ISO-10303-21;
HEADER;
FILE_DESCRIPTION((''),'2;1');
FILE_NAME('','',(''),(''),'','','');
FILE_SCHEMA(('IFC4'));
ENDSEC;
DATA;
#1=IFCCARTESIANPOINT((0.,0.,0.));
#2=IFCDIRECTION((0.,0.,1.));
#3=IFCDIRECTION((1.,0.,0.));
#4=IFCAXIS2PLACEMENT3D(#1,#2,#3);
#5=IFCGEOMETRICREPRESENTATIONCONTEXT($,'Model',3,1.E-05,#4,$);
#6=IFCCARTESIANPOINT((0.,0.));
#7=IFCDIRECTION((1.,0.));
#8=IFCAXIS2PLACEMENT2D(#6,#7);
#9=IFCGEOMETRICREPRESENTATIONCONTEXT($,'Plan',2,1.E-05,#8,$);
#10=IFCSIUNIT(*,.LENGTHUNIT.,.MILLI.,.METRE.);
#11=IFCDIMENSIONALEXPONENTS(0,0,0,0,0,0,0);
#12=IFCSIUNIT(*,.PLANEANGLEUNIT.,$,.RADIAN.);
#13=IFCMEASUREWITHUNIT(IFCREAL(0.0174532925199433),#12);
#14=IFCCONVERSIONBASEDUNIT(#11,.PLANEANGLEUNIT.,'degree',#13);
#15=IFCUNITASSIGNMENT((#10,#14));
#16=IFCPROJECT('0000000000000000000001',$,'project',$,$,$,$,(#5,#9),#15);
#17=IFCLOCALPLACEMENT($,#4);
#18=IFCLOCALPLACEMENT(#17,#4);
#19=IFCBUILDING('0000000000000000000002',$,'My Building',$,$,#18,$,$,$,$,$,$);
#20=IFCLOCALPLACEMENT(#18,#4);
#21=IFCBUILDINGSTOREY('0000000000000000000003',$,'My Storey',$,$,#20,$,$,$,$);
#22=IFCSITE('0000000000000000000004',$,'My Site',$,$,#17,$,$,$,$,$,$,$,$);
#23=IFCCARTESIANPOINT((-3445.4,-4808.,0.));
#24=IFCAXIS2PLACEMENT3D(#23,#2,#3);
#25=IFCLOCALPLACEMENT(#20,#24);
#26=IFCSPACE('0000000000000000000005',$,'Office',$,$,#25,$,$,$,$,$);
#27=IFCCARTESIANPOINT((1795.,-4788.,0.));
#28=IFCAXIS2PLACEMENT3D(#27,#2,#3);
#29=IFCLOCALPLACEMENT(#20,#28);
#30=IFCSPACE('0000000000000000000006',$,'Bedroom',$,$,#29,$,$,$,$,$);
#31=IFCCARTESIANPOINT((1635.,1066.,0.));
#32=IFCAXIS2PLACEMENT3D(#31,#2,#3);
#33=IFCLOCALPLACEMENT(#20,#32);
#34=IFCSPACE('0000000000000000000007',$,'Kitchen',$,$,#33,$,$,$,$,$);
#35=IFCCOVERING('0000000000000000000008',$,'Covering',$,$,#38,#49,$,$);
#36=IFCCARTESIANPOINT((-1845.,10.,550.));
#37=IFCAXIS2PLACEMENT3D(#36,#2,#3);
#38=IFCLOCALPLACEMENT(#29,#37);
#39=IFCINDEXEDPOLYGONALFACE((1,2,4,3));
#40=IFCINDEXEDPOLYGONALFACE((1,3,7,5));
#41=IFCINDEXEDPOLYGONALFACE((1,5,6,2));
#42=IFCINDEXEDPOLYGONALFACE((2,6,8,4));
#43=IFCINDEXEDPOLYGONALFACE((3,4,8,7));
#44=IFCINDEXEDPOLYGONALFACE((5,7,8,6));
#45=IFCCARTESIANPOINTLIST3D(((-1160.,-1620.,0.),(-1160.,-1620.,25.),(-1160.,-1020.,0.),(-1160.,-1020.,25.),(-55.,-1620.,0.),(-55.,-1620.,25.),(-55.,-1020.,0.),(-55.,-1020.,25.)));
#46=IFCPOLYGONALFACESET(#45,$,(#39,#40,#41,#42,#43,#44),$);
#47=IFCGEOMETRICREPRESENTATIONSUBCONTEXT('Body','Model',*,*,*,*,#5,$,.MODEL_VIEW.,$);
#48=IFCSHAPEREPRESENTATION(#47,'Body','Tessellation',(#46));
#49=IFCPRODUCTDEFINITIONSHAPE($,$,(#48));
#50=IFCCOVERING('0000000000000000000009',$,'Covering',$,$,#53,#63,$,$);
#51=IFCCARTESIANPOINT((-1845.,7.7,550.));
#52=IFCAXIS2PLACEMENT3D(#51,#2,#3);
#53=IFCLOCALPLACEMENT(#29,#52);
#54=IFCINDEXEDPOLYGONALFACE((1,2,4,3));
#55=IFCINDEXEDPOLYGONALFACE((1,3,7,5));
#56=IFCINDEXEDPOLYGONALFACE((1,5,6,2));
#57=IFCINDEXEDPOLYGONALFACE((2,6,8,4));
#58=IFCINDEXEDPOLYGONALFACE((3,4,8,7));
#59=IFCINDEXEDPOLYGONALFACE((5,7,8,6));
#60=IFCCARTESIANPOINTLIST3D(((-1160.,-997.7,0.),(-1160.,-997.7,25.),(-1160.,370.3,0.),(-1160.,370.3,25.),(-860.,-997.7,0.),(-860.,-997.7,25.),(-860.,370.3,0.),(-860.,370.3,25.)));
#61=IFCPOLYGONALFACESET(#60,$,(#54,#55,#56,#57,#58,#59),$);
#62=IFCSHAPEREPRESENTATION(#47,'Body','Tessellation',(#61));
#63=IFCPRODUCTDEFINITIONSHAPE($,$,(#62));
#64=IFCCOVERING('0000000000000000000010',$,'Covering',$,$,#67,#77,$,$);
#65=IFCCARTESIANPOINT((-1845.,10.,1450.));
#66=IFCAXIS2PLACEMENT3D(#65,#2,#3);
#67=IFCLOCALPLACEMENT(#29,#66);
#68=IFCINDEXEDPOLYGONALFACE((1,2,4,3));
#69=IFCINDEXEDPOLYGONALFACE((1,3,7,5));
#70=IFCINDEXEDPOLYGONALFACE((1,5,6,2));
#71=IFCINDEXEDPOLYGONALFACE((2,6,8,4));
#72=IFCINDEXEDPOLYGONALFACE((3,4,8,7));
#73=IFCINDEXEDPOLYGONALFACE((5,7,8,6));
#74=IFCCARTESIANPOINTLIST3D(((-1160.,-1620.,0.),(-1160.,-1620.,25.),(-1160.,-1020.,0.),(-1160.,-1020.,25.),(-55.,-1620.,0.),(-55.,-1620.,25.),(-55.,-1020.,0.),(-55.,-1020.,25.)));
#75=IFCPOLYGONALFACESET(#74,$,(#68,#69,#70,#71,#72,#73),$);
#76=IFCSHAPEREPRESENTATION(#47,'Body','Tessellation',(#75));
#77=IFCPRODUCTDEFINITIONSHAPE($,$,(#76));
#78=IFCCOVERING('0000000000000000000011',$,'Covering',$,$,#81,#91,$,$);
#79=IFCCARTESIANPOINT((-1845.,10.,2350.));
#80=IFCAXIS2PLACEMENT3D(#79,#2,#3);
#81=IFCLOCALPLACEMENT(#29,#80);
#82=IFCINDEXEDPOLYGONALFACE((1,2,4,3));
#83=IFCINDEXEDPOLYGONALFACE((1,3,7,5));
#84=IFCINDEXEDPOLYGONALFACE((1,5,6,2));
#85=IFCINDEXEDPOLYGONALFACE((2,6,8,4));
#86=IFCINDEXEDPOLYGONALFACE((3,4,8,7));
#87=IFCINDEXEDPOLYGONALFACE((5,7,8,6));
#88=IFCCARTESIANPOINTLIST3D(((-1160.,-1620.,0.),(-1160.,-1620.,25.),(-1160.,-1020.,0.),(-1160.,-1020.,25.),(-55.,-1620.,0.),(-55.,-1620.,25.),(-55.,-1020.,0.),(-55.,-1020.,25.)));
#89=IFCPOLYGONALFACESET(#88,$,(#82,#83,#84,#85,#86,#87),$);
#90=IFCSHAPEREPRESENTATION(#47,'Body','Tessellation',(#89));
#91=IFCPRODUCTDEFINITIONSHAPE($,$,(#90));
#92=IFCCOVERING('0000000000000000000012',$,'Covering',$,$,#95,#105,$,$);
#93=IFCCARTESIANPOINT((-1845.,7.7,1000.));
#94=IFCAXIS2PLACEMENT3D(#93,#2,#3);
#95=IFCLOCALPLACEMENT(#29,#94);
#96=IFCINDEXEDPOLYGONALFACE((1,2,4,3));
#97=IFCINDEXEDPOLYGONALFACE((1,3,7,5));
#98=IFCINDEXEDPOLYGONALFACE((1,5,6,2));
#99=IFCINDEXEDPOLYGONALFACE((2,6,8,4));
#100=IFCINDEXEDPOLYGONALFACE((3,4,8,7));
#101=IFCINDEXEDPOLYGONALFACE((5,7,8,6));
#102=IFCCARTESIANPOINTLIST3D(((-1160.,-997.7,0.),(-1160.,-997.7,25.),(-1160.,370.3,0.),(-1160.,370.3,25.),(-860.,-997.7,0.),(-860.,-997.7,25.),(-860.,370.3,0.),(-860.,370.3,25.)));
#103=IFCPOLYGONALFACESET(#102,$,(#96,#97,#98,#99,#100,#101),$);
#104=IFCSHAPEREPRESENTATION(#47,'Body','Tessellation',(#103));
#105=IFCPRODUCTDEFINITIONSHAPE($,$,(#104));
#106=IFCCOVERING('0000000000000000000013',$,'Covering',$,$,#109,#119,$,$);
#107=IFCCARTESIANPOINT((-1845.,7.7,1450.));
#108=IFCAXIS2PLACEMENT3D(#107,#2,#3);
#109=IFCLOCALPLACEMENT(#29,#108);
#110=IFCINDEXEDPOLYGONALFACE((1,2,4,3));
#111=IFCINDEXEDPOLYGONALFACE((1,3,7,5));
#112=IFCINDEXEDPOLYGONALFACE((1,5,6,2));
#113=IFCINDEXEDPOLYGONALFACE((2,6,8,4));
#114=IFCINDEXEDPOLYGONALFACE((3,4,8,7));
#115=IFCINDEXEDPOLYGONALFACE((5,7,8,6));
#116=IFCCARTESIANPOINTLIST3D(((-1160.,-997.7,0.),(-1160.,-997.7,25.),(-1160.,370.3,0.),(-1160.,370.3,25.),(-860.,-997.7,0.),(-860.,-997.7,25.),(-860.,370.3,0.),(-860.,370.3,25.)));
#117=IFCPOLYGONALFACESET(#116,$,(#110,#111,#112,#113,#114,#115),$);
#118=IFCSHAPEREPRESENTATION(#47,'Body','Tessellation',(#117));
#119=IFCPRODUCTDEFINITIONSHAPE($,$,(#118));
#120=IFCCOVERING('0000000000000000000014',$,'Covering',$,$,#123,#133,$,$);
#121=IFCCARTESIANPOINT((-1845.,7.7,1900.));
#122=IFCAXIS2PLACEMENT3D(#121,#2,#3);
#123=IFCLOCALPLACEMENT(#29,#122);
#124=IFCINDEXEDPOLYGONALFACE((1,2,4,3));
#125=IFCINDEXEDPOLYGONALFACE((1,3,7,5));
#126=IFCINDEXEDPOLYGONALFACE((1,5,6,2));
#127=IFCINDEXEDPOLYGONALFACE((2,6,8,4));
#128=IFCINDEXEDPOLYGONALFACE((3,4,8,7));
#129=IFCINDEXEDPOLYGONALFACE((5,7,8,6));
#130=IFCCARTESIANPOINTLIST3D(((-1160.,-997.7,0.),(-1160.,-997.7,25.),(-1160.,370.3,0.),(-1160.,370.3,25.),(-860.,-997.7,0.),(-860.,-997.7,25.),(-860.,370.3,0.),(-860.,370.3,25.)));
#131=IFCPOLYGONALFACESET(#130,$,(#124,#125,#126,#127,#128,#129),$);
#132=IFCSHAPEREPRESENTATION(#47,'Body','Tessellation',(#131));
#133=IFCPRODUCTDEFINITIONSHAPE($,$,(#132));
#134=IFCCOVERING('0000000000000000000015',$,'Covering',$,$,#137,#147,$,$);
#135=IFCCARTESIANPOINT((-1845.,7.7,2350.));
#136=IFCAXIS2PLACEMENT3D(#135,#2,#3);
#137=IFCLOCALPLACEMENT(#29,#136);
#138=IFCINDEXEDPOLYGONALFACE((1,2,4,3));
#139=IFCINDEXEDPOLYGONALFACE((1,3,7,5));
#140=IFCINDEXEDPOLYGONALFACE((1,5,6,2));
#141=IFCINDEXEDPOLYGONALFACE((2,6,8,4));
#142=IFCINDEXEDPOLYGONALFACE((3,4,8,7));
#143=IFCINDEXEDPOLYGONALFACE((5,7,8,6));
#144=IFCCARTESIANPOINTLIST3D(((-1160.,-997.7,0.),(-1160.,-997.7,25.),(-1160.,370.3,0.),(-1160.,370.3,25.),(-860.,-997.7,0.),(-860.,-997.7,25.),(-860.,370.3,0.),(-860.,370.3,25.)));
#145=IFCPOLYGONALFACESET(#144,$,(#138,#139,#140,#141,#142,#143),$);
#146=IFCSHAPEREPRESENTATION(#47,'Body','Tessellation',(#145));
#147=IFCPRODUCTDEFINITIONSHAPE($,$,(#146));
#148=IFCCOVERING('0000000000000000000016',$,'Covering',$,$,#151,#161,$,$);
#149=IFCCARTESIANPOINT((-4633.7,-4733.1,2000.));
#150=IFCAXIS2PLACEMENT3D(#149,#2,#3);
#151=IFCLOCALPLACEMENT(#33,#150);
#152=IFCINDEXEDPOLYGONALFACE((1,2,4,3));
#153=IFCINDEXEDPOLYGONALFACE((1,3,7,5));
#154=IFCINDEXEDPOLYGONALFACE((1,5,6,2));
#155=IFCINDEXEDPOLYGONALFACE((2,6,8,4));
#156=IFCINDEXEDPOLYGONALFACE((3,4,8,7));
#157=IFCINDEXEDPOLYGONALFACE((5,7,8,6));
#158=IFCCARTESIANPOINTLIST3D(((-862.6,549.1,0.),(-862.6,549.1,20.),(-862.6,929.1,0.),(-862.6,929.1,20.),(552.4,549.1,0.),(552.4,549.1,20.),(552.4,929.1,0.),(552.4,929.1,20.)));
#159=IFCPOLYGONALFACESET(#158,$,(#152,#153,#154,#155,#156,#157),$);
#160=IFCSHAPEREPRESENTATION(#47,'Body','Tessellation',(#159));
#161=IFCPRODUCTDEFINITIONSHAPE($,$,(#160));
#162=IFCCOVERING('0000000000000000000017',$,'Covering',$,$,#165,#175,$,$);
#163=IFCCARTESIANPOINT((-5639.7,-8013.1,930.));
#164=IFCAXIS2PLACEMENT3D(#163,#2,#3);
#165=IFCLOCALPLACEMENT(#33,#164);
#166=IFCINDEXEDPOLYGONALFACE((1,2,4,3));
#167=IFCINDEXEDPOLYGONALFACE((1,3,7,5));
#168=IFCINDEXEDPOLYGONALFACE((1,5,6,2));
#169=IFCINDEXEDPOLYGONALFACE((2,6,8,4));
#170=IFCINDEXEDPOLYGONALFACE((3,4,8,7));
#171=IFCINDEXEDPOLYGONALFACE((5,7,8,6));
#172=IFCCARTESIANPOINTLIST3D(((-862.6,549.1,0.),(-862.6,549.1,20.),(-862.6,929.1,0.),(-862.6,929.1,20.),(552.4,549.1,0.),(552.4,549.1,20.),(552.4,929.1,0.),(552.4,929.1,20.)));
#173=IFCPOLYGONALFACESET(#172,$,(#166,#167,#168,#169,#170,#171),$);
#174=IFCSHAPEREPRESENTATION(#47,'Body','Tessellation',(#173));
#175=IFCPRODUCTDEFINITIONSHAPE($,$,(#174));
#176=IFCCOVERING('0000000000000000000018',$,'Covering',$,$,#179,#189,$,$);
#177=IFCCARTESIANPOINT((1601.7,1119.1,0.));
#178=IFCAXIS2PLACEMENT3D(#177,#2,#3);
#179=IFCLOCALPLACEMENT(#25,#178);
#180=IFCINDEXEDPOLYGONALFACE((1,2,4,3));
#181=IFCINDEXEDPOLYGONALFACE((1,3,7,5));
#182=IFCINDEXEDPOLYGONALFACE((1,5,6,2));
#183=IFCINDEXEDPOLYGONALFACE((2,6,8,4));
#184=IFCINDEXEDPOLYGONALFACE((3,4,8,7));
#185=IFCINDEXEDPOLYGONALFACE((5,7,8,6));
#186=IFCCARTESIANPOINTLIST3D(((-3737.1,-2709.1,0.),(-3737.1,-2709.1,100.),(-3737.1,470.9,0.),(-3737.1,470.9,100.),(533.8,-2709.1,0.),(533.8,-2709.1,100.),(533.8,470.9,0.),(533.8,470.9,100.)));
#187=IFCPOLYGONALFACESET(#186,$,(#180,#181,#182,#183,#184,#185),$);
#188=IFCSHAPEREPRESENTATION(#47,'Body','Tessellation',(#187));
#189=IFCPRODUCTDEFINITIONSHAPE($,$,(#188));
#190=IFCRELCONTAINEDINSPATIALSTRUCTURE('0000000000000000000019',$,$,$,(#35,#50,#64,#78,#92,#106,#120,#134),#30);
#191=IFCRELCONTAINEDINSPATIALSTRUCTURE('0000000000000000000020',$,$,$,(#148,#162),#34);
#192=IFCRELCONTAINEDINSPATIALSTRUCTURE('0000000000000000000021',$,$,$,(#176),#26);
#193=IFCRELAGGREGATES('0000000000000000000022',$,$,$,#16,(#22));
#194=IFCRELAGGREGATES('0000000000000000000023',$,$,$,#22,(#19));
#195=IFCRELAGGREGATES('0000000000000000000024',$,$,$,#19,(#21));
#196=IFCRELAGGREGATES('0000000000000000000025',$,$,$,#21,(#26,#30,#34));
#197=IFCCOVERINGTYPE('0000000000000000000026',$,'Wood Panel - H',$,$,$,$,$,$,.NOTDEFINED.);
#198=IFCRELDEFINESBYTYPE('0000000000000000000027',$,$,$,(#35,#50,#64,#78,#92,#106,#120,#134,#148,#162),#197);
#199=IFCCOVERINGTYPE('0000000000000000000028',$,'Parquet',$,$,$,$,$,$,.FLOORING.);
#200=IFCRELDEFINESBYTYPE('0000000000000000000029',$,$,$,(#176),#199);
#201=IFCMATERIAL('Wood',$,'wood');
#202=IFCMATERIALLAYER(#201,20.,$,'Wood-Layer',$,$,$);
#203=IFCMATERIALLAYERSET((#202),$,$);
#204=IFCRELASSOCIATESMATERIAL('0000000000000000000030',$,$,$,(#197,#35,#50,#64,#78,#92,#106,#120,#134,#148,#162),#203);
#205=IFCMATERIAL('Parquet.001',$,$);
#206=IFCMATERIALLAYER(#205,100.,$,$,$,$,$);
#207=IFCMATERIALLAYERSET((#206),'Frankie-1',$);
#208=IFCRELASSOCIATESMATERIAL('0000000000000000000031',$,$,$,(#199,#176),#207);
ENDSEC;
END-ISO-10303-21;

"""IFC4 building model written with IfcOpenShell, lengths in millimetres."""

from ifc_helpers import new_model, entity, si_unit, converted_unit, frame, origin_with_axes, origin_2d_with_axis, place, context, subcontext, project, spatial, line, indexed_curve, outline, extrude, material, layer, layer_set, layer_usage, type_object, element, save


model = new_model("IFC4")

# Units and contexts
model_context = context("Model", 3, precision=1e-05, world=origin_with_axes())
plan_context = context("Plan", 2, precision=1e-05, world=origin_2d_with_axis())
body_context_1 = subcontext(model_context, "Body", "Model", "MODEL_VIEW")
ifc_project = project(units=[si_unit("LENGTHUNIT", "METRE", prefix="MILLI"), converted_unit("PLANEANGLEUNIT", "degree", entity("IfcReal", 0.0174532925199433), si_unit("PLANEANGLEUNIT", "RADIAN"), dimensions=[0, 0, 0, 0, 0, 0, 0])], contexts=[model_context, plan_context])

# Site, building, storey
site_placement = place(None, origin_with_axes())
site = spatial("IfcSite", under=ifc_project, at=site_placement, Name="My Site")
building_placement = place(site_placement, origin_with_axes())
building = spatial("IfcBuilding", under=site, at=building_placement, Name="My Building")
storey_placement = place(building_placement, origin_with_axes())
storey = spatial("IfcBuildingStorey", under=building, at=storey_placement, Name="My Storey")

# Shared definitions
space_1_placement = place(storey_placement, frame((-3445.4, -4808.0, 0.0), z_axis=(0.0, 0.0, 1.0), x_axis=(1.0, 0.0, 0.0)))
space_1 = spatial("IfcSpace", under=storey, at=space_1_placement, Name="Office")

# Shared definitions
space_2_placement = place(storey_placement, frame((1795.0, -4788.0, 0.0), z_axis=(0.0, 0.0, 1.0), x_axis=(1.0, 0.0, 0.0)))
space_2 = spatial("IfcSpace", under=storey, at=space_2_placement, Name="Bedroom")

# Coverings
ifc_material_1 = material(Name="Wood", Category="wood")
ifc_layer_1 = layer(ifc_material_1, 20.0, Name="Wood-Layer")
ifc_layer_set_1 = layer_set([ifc_layer_1])
covering_type_1 = type_object("IfcCoveringType", Name="Wood Panel - H", PredefinedType="NOTDEFINED", material=ifc_layer_set_1)
ifc_layer_usage_1 = layer_usage(ifc_layer_set_1, "AXIS3", "POSITIVE", 0.0)
covering_1_placement = place(space_2_placement, frame((-1845.0, 10.0, 550.0), z_axis=(0.0, 0.0, 1.0), x_axis=(1.0, 0.0, 0.0)))
element("IfcCovering", 1, at=covering_1_placement, inside=space_2, type_object=covering_type_1, material=ifc_layer_usage_1, Name="Covering", context=body_context_1, shape_type="SweptSolid", body=[
    extrude(outline(indexed_curve([(-55.0, -1020.0), (-1160.0, -1020.0), (-1160.0, -1620.0), (-55.0, -1620.0)], segments=[line(3, 2), line(2, 1), line(1, 4), line(4, 3)], self_intersect=False)), None, (0.0, 0.0, 1.0), 25.0),
])
ifc_layer_usage_2 = layer_usage(ifc_layer_set_1, "AXIS3", "POSITIVE", 0.0)
covering_2_placement = place(space_2_placement, frame((-1845.0, 7.7, 550.0), z_axis=(0.0, 0.0, 1.0), x_axis=(1.0, 0.0, 0.0)))
element("IfcCovering", 2, at=covering_2_placement, inside=space_2, type_object=covering_type_1, material=ifc_layer_usage_2, Name="Covering", context=body_context_1, shape_type="SweptSolid", body=[
    extrude(outline(indexed_curve([(-860.0, 370.3), (-860.0, -997.7), (-1160.0, -997.7), (-1160.0, 370.3)], segments=[line(3, 2), line(2, 1), line(1, 4), line(4, 3)], self_intersect=False)), None, (0.0, 0.0, 1.0), 25.0),
])
ifc_layer_usage_3 = layer_usage(ifc_layer_set_1, "AXIS3", "POSITIVE", 0.0)
covering_3_placement = place(space_2_placement, frame((-1845.0, 10.0, 1450.0), z_axis=(0.0, 0.0, 1.0), x_axis=(1.0, 0.0, 0.0)))
element("IfcCovering", 3, at=covering_3_placement, inside=space_2, type_object=covering_type_1, material=ifc_layer_usage_3, Name="Covering", context=body_context_1, shape_type="SweptSolid", body=[
    extrude(outline(indexed_curve([(-55.0, -1020.0), (-1160.0, -1020.0), (-1160.0, -1620.0), (-55.0, -1620.0)], segments=[line(3, 2), line(2, 1), line(1, 4), line(4, 3)], self_intersect=False)), None, (0.0, 0.0, 1.0), 25.0),
])
ifc_layer_usage_4 = layer_usage(ifc_layer_set_1, "AXIS3", "POSITIVE", 0.0)
covering_4_placement = place(space_2_placement, frame((-1845.0, 10.0, 2350.0), z_axis=(0.0, 0.0, 1.0), x_axis=(1.0, 0.0, 0.0)))
element("IfcCovering", 4, at=covering_4_placement, inside=space_2, type_object=covering_type_1, material=ifc_layer_usage_4, Name="Covering", context=body_context_1, shape_type="SweptSolid", body=[
    extrude(outline(indexed_curve([(-55.0, -1020.0), (-1160.0, -1020.0), (-1160.0, -1620.0), (-55.0, -1620.0)], segments=[line(3, 2), line(2, 1), line(1, 4), line(4, 3)], self_intersect=False)), None, (0.0, 0.0, 1.0), 25.0),
])
ifc_layer_usage_5 = layer_usage(ifc_layer_set_1, "AXIS3", "POSITIVE", 0.0)
covering_5_placement = place(space_2_placement, frame((-1845.0, 7.7, 1000.0), z_axis=(0.0, 0.0, 1.0), x_axis=(1.0, 0.0, 0.0)))
element("IfcCovering", 5, at=covering_5_placement, inside=space_2, type_object=covering_type_1, material=ifc_layer_usage_5, Name="Covering", context=body_context_1, shape_type="SweptSolid", body=[
    extrude(outline(indexed_curve([(-860.0, 370.3), (-860.0, -997.7), (-1160.0, -997.7), (-1160.0, 370.3)], segments=[line(3, 2), line(2, 1), line(1, 4), line(4, 3)], self_intersect=False)), None, (0.0, 0.0, 1.0), 25.0),
])
ifc_layer_usage_6 = layer_usage(ifc_layer_set_1, "AXIS3", "POSITIVE", 0.0)
covering_6_placement = place(space_2_placement, frame((-1845.0, 7.7, 1450.0), z_axis=(0.0, 0.0, 1.0), x_axis=(1.0, 0.0, 0.0)))
element("IfcCovering", 6, at=covering_6_placement, inside=space_2, type_object=covering_type_1, material=ifc_layer_usage_6, Name="Covering", context=body_context_1, shape_type="SweptSolid", body=[
    extrude(outline(indexed_curve([(-860.0, 370.3), (-860.0, -997.7), (-1160.0, -997.7), (-1160.0, 370.3)], segments=[line(3, 2), line(2, 1), line(1, 4), line(4, 3)], self_intersect=False)), None, (0.0, 0.0, 1.0), 25.0),
])
ifc_layer_usage_7 = layer_usage(ifc_layer_set_1, "AXIS3", "POSITIVE", 0.0)
covering_7_placement = place(space_2_placement, frame((-1845.0, 7.7, 1900.0), z_axis=(0.0, 0.0, 1.0), x_axis=(1.0, 0.0, 0.0)))
element("IfcCovering", 7, at=covering_7_placement, inside=space_2, type_object=covering_type_1, material=ifc_layer_usage_7, Name="Covering", context=body_context_1, shape_type="SweptSolid", body=[
    extrude(outline(indexed_curve([(-860.0, 370.3), (-860.0, -997.7), (-1160.0, -997.7), (-1160.0, 370.3)], segments=[line(3, 2), line(2, 1), line(1, 4), line(4, 3)], self_intersect=False)), None, (0.0, 0.0, 1.0), 25.0),
])
ifc_layer_usage_8 = layer_usage(ifc_layer_set_1, "AXIS3", "POSITIVE", 0.0)
covering_8_placement = place(space_2_placement, frame((-1845.0, 7.7, 2350.0), z_axis=(0.0, 0.0, 1.0), x_axis=(1.0, 0.0, 0.0)))
element("IfcCovering", 8, at=covering_8_placement, inside=space_2, type_object=covering_type_1, material=ifc_layer_usage_8, Name="Covering", context=body_context_1, shape_type="SweptSolid", body=[
    extrude(outline(indexed_curve([(-860.0, 370.3), (-860.0, -997.7), (-1160.0, -997.7), (-1160.0, 370.3)], segments=[line(3, 2), line(2, 1), line(1, 4), line(4, 3)], self_intersect=False)), None, (0.0, 0.0, 1.0), 25.0),
])

# Shared definitions
space_3_placement = place(storey_placement, frame((1635.0, 1066.0, 0.0), z_axis=(0.0, 0.0, 1.0), x_axis=(1.0, 0.0, 0.0)))
space_3 = spatial("IfcSpace", under=storey, at=space_3_placement, Name="Kitchen")

# Coverings
ifc_layer_usage_9 = layer_usage(ifc_layer_set_1, "AXIS3", "POSITIVE", 0.0)
covering_9_placement = place(space_3_placement, frame((-4633.7, -4733.1, 2000.0), z_axis=(0.0, 0.0, 1.0), x_axis=(1.0, 0.0, 0.0)))
element("IfcCovering", 9, at=covering_9_placement, inside=space_3, type_object=covering_type_1, material=ifc_layer_usage_9, Name="Covering", context=body_context_1, shape_type="SweptSolid", body=[
    extrude(outline(indexed_curve([(552.4, 549.1), (552.4, 929.1), (-862.6, 929.1), (-862.6, 549.1), (552.4, 549.1)])), None, (0.0, 0.0, 1.0), 20.0),
])
ifc_layer_usage_10 = layer_usage(ifc_layer_set_1, "AXIS3", "POSITIVE", 0.0)
covering_10_placement = place(space_3_placement, frame((-5639.7, -8013.1, 930.0), z_axis=(0.0, 0.0, 1.0), x_axis=(1.0, 0.0, 0.0)))
element("IfcCovering", 10, at=covering_10_placement, inside=space_3, type_object=covering_type_1, material=ifc_layer_usage_10, Name="Covering", context=body_context_1, shape_type="SweptSolid", body=[
    extrude(outline(indexed_curve([(552.4, 549.1), (552.4, 929.1), (-862.6, 929.1), (-862.6, 549.1), (552.4, 549.1)])), None, (0.0, 0.0, 1.0), 20.0),
])
ifc_material_2 = material(Name="Parquet.001")
ifc_layer_2 = layer(ifc_material_2, 100.0)
ifc_layer_set_2 = layer_set([ifc_layer_2], Name="Frankie-1")
ifc_layer_usage_11 = layer_usage(ifc_layer_set_2, "AXIS3", "POSITIVE", 0.0)
covering_type_2 = type_object("IfcCoveringType", Name="Parquet", PredefinedType="FLOORING", material=ifc_layer_set_2)
covering_11_placement = place(space_1_placement, frame((1601.7, 1119.1, 0.0), z_axis=(0.0, 0.0, 1.0), x_axis=(1.0, 0.0, 0.0)))
element("IfcCovering", 11, at=covering_11_placement, inside=space_1, type_object=covering_type_2, material=ifc_layer_usage_11, Name="Covering", context=body_context_1, shape_type="SweptSolid", body=[
    extrude(outline(indexed_curve([(533.8, -2709.1), (533.8, 470.9), (-3737.1, 470.9), (-3737.1, -2709.1)], segments=[line(4, 1), line(1, 2), line(2, 3), line(3, 4)], self_intersect=False)), None, (0.0, 0.0, 1.0), 100.0),
])

save(model, "model.ifc")
